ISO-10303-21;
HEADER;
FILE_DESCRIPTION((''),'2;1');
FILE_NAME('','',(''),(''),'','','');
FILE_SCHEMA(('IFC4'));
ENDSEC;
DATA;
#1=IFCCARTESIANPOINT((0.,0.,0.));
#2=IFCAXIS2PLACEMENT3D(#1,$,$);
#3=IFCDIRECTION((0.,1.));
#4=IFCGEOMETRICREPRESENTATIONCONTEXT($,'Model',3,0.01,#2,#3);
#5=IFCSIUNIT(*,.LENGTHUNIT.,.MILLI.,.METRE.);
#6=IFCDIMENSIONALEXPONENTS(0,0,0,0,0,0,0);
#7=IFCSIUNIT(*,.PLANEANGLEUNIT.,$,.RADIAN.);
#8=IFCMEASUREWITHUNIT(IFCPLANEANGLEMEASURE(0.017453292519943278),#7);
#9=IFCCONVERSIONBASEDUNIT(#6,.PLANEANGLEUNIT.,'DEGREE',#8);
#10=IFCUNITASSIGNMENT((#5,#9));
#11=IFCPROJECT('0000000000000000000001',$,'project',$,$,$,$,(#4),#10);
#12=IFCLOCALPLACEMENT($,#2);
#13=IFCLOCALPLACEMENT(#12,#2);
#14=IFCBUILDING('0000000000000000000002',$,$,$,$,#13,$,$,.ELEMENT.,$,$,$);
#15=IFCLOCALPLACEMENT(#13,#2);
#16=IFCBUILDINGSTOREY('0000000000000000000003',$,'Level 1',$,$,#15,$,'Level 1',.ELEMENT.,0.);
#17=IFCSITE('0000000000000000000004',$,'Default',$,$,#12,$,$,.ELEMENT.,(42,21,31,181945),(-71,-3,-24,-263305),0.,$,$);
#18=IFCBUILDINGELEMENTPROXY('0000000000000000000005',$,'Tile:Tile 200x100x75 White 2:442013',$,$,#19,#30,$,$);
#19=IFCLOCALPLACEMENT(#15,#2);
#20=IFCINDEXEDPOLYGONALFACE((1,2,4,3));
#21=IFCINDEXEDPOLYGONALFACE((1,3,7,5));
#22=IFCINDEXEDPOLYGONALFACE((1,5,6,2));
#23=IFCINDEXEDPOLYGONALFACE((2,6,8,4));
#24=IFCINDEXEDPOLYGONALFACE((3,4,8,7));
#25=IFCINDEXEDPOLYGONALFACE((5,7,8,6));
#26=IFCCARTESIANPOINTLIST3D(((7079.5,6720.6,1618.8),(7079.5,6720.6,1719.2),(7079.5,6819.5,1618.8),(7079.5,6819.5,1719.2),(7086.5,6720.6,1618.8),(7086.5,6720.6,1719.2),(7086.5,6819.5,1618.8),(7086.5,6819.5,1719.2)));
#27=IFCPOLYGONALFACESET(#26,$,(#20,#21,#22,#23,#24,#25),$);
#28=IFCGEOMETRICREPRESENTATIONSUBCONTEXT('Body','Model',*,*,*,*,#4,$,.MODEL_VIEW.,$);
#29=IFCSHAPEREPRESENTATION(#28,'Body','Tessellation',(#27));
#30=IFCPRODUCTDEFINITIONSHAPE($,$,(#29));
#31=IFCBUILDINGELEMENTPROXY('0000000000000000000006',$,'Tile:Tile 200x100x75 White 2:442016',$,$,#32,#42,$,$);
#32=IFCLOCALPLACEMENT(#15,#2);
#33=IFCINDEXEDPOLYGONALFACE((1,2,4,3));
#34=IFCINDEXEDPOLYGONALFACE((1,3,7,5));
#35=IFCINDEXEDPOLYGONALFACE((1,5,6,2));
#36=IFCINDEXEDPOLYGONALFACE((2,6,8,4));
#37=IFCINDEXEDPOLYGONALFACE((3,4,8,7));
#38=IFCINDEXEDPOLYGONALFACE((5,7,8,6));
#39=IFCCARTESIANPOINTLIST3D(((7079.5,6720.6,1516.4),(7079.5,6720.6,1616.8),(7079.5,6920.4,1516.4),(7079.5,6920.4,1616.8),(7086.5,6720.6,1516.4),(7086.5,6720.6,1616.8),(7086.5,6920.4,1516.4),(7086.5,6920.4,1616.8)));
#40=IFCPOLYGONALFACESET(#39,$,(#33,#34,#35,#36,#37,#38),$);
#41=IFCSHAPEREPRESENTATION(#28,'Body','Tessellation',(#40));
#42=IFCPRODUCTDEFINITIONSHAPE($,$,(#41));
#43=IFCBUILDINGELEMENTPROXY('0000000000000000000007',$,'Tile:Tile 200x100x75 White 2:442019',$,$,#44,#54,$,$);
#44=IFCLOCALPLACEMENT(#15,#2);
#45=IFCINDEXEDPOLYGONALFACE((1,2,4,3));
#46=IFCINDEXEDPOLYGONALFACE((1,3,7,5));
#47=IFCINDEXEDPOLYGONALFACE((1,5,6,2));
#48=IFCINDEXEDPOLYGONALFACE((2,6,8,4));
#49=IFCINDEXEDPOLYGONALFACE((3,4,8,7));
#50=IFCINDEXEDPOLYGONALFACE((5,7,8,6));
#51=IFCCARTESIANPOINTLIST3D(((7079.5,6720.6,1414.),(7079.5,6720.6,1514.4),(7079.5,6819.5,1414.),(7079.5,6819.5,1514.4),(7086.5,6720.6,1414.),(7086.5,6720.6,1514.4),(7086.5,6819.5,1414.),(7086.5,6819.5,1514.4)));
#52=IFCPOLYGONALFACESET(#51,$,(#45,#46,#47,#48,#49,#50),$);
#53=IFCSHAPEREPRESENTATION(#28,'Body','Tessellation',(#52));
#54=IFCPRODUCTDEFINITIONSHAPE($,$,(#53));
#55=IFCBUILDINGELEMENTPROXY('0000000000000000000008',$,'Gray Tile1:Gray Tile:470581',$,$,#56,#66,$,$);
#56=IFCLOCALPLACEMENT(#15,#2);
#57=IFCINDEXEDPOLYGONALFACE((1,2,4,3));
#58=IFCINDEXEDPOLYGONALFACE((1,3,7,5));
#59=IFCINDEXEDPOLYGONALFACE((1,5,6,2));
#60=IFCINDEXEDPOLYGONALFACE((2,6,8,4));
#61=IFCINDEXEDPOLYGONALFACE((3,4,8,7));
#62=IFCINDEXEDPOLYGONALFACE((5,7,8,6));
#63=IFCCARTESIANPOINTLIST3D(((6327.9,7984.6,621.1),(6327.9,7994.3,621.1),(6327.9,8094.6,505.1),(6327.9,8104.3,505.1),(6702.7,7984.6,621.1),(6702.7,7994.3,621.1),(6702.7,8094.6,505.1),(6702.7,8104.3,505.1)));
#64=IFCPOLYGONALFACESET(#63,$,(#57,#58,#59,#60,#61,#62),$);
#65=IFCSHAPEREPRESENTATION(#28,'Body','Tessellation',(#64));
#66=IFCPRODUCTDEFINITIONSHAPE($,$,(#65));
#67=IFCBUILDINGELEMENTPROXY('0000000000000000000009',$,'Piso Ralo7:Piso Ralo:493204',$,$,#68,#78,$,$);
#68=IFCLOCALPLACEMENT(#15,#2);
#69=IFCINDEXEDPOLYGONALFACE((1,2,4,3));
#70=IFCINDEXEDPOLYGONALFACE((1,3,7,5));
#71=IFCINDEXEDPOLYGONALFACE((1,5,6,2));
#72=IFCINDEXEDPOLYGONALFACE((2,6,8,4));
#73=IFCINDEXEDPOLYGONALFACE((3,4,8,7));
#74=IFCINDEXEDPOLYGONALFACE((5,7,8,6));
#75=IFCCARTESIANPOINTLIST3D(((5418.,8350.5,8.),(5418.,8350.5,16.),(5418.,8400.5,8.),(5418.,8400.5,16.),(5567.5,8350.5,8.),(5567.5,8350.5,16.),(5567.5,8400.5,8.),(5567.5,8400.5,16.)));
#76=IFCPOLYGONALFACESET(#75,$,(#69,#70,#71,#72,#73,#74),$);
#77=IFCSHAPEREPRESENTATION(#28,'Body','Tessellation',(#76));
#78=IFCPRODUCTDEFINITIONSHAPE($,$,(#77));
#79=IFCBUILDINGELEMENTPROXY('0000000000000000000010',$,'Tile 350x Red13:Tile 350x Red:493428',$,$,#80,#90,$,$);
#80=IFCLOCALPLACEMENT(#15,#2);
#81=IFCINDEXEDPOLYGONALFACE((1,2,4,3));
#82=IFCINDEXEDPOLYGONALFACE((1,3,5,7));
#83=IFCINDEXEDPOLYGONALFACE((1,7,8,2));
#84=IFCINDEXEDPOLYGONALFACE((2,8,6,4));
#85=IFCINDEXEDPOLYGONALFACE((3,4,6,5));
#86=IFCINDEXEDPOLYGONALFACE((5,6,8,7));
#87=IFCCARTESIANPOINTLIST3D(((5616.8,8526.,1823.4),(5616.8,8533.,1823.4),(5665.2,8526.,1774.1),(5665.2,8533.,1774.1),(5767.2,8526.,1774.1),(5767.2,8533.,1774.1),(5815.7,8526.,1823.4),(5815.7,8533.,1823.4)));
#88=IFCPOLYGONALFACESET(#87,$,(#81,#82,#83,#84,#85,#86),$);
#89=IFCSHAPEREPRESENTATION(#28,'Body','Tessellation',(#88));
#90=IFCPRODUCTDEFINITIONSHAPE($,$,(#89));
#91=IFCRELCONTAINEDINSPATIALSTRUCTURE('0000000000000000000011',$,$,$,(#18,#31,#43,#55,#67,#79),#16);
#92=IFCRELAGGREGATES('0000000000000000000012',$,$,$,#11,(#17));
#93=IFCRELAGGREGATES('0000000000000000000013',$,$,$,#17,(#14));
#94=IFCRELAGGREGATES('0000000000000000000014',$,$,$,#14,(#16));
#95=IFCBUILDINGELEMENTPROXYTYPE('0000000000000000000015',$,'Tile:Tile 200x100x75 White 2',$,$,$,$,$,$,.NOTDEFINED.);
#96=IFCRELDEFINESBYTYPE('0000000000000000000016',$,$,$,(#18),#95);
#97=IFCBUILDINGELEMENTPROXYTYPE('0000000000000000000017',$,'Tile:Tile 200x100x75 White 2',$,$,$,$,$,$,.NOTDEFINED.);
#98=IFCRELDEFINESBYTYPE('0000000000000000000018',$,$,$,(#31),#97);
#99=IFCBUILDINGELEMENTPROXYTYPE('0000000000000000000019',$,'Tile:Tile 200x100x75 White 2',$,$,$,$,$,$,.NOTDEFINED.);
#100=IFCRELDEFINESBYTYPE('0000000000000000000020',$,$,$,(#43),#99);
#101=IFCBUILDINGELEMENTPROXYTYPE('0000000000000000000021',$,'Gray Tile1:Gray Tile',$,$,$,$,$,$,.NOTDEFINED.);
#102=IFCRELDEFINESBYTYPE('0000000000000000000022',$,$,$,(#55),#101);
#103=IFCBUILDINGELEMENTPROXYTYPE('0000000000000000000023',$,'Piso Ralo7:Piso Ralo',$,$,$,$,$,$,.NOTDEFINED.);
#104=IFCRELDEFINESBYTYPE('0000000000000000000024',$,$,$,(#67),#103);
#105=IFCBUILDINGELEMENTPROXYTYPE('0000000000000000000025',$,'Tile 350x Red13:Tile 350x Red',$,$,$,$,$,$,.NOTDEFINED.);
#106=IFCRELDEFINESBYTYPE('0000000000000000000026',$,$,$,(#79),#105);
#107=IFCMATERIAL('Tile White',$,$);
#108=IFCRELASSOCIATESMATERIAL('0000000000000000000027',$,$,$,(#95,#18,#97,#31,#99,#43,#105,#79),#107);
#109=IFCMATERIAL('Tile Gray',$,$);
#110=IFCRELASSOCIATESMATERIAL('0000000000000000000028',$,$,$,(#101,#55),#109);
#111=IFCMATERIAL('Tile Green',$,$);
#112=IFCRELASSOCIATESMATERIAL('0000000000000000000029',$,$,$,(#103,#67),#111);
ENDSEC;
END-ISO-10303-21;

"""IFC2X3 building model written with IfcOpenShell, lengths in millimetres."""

from ifc_helpers import new_model, entity, si_unit, converted_unit, direction, frame, frame_2d, origin, origin_2d_with_axis, place, context, subcontext, project, spatial, polyline, rectangle, outline, extrude, source, transform, mapped, material, type_object, type_shapes, element, save


model = new_model("IFC2X3")

# Units and contexts
model_context = context("Model", 3, precision=0.01, world=origin(), true_north=direction((0.0, 1.0)))
body_context = subcontext(model_context, "Body", "Model", "MODEL_VIEW")
ifc_project = project(units=[si_unit("LENGTHUNIT", "METRE", prefix="MILLI"), converted_unit("PLANEANGLEUNIT", "DEGREE", entity("IfcPlaneAngleMeasure", 0.017453292519943278), si_unit("PLANEANGLEUNIT", "RADIAN"), dimensions=[0, 0, 0, 0, 0, 0, 0])], contexts=[model_context])

# Site, building, storey
site_placement = place(None, origin())
site = spatial("IfcSite", under=ifc_project, at=site_placement, Name="Default", CompositionType="ELEMENT", RefLatitude=(42, 21, 31, 181945), RefLongitude=(-71, -3, -24, -263305), RefElevation=0.0)
building_placement = place(site_placement, origin())
building = spatial("IfcBuilding", under=site, at=building_placement, CompositionType="ELEMENT")
storey_placement = place(building_placement, origin())
storey = spatial("IfcBuildingStorey", under=building, at=storey_placement, Name="Level 1", LongName="Level 1", CompositionType="ELEMENT", Elevation=0.0)

# Building element proxies
ifc_material_1 = material(Name="Tile White")
building_element_proxy_type_1 = type_object("IfcBuildingElementProxyType", Name="Tile:Tile 200x100x75 White 2", PredefinedType="NOTDEFINED", material=ifc_material_1)
shared_shape_1 = source(origin(), body_context, "Body", "SweptSolid", [
    extrude(rectangle(XDim=100.4, YDim=98.9, at=origin_2d_with_axis()), frame((-50.2, 49.5, 0.0)), (0.0, 0.0, 1.0), 7.0),
])
type_shapes(building_element_proxy_type_1, [shared_shape_1])
proxy_1_placement = place(storey_placement, frame((7086.5, 6720.6, 1719.2), z_axis=(-1.0, 0.0, 0.0), x_axis=(0.0, 0.0, 1.0)))
element("IfcBuildingElementProxy", 1, at=proxy_1_placement, inside=storey, type_object=building_element_proxy_type_1, material=ifc_material_1, Name="Tile:Tile 200x100x75 White 2:442013", context=body_context, shape_type="MappedRepresentation", body=[
    mapped(shared_shape_1, transform((0.0, 0.0, 0.0), scale=1.0)),
])
building_element_proxy_type_2 = type_object("IfcBuildingElementProxyType", Name="Tile:Tile 200x100x75 White 2", PredefinedType="NOTDEFINED", material=ifc_material_1)
shared_shape_2 = source(origin(), body_context, "Body", "SweptSolid", [
    extrude(rectangle(XDim=100.4, YDim=199.8, at=origin_2d_with_axis()), frame((-50.2, 99.9, 0.0)), (0.0, 0.0, 1.0), 7.0),
])
type_shapes(building_element_proxy_type_2, [shared_shape_2])
proxy_2_placement = place(storey_placement, frame((7086.5, 6720.6, 1616.8), z_axis=(-1.0, 0.0, 0.0), x_axis=(0.0, 0.0, 1.0)))
element("IfcBuildingElementProxy", 2, at=proxy_2_placement, inside=storey, type_object=building_element_proxy_type_2, material=ifc_material_1, Name="Tile:Tile 200x100x75 White 2:442016", context=body_context, shape_type="MappedRepresentation", body=[
    mapped(shared_shape_2, transform((0.0, 0.0, 0.0), scale=1.0)),
])
building_element_proxy_type_3 = type_object("IfcBuildingElementProxyType", Name="Tile:Tile 200x100x75 White 2", PredefinedType="NOTDEFINED", material=ifc_material_1)
shared_shape_3 = source(origin(), body_context, "Body", "SweptSolid", [
    extrude(rectangle(XDim=100.4, YDim=98.9, at=origin_2d_with_axis()), frame((-50.2, 49.5, 0.0)), (0.0, 0.0, 1.0), 7.0),
])
type_shapes(building_element_proxy_type_3, [shared_shape_3])
proxy_3_placement = place(storey_placement, frame((7086.5, 6720.6, 1514.4), z_axis=(-1.0, 0.0, 0.0), x_axis=(0.0, 0.0, 1.0)))
element("IfcBuildingElementProxy", 3, at=proxy_3_placement, inside=storey, type_object=building_element_proxy_type_3, material=ifc_material_1, Name="Tile:Tile 200x100x75 White 2:442019", context=body_context, shape_type="MappedRepresentation", body=[
    mapped(shared_shape_3, transform((0.0, 0.0, 0.0), scale=1.0)),
])
ifc_material_2 = material(Name="Tile Gray")
building_element_proxy_type_4 = type_object("IfcBuildingElementProxyType", Name="Gray Tile1:Gray Tile", PredefinedType="NOTDEFINED", material=ifc_material_2)
shared_shape_4 = source(origin(), body_context, "Body", "SweptSolid", [
    extrude(outline(polyline([(-83.3, -3.5), (76.6, -3.5), (83.3, 3.5), (-76.6, 3.5), (-83.3, -3.5)])), frame((6327.9, 8039.2, 555.7), z_axis=(1.0, 0.0, 0.0), x_axis=(0.0, -0.688092, 0.725624)), (0.0, 0.0, 1.0), 374.8),
])
type_shapes(building_element_proxy_type_4, [shared_shape_4])
proxy_4_placement = place(storey_placement, frame((0.0, 5.2, 7.5)))
element("IfcBuildingElementProxy", 4, at=proxy_4_placement, inside=storey, type_object=building_element_proxy_type_4, material=ifc_material_2, Name="Gray Tile1:Gray Tile:470581", context=body_context, shape_type="MappedRepresentation", body=[
    mapped(shared_shape_4, transform((0.0, 0.0, 0.0), scale=1.0)),
])
ifc_material_3 = material(Name="Tile Green")
building_element_proxy_type_5 = type_object("IfcBuildingElementProxyType", Name="Piso Ralo7:Piso Ralo", PredefinedType="NOTDEFINED", material=ifc_material_3)
shared_shape_5 = source(origin(), body_context, "Body", "SweptSolid", [
    extrude(rectangle(XDim=149.5, YDim=50.0, at=frame_2d((0.0, 0.0), x_axis=(1.0, 0.0))), frame((5492.7, 8375.5, 8.0), z_axis=(0.0, 0.0, 1.0), x_axis=(-1.0, 0.0, 0.0)), (0.0, 0.0, 1.0), 8.0),
])
type_shapes(building_element_proxy_type_5, [shared_shape_5])
proxy_5_placement = place(storey_placement, origin())
element("IfcBuildingElementProxy", 5, at=proxy_5_placement, inside=storey, type_object=building_element_proxy_type_5, material=ifc_material_3, Name="Piso Ralo7:Piso Ralo:493204", context=body_context, shape_type="MappedRepresentation", body=[
    mapped(shared_shape_5, transform((0.0, 0.0, 0.0), scale=1.0)),
])
building_element_proxy_type_6 = type_object("IfcBuildingElementProxyType", Name="Tile 350x Red13:Tile 350x Red", PredefinedType="NOTDEFINED", material=ifc_material_1)
shared_shape_6 = source(origin(), body_context, "Body", "SweptSolid", [
    extrude(outline(polyline([(-99.4, -24.7), (99.4, -24.7), (51.0, 24.7), (-51.0, 24.7), (-99.4, -24.7)])), frame((5716.2, 8526.0, 1798.7), z_axis=(0.0, 1.0, 0.0), x_axis=(1.0, 0.0, 0.0)), (0.0, 0.0, 1.0), 7.0),
])
type_shapes(building_element_proxy_type_6, [shared_shape_6])
proxy_6_placement = place(storey_placement, origin())
element("IfcBuildingElementProxy", 6, at=proxy_6_placement, inside=storey, type_object=building_element_proxy_type_6, material=ifc_material_1, Name="Tile 350x Red13:Tile 350x Red:493428", context=body_context, shape_type="MappedRepresentation", body=[
    mapped(shared_shape_6, transform((0.0, 0.0, 0.0), scale=1.0)),
])

save(model, "model.ifc")
